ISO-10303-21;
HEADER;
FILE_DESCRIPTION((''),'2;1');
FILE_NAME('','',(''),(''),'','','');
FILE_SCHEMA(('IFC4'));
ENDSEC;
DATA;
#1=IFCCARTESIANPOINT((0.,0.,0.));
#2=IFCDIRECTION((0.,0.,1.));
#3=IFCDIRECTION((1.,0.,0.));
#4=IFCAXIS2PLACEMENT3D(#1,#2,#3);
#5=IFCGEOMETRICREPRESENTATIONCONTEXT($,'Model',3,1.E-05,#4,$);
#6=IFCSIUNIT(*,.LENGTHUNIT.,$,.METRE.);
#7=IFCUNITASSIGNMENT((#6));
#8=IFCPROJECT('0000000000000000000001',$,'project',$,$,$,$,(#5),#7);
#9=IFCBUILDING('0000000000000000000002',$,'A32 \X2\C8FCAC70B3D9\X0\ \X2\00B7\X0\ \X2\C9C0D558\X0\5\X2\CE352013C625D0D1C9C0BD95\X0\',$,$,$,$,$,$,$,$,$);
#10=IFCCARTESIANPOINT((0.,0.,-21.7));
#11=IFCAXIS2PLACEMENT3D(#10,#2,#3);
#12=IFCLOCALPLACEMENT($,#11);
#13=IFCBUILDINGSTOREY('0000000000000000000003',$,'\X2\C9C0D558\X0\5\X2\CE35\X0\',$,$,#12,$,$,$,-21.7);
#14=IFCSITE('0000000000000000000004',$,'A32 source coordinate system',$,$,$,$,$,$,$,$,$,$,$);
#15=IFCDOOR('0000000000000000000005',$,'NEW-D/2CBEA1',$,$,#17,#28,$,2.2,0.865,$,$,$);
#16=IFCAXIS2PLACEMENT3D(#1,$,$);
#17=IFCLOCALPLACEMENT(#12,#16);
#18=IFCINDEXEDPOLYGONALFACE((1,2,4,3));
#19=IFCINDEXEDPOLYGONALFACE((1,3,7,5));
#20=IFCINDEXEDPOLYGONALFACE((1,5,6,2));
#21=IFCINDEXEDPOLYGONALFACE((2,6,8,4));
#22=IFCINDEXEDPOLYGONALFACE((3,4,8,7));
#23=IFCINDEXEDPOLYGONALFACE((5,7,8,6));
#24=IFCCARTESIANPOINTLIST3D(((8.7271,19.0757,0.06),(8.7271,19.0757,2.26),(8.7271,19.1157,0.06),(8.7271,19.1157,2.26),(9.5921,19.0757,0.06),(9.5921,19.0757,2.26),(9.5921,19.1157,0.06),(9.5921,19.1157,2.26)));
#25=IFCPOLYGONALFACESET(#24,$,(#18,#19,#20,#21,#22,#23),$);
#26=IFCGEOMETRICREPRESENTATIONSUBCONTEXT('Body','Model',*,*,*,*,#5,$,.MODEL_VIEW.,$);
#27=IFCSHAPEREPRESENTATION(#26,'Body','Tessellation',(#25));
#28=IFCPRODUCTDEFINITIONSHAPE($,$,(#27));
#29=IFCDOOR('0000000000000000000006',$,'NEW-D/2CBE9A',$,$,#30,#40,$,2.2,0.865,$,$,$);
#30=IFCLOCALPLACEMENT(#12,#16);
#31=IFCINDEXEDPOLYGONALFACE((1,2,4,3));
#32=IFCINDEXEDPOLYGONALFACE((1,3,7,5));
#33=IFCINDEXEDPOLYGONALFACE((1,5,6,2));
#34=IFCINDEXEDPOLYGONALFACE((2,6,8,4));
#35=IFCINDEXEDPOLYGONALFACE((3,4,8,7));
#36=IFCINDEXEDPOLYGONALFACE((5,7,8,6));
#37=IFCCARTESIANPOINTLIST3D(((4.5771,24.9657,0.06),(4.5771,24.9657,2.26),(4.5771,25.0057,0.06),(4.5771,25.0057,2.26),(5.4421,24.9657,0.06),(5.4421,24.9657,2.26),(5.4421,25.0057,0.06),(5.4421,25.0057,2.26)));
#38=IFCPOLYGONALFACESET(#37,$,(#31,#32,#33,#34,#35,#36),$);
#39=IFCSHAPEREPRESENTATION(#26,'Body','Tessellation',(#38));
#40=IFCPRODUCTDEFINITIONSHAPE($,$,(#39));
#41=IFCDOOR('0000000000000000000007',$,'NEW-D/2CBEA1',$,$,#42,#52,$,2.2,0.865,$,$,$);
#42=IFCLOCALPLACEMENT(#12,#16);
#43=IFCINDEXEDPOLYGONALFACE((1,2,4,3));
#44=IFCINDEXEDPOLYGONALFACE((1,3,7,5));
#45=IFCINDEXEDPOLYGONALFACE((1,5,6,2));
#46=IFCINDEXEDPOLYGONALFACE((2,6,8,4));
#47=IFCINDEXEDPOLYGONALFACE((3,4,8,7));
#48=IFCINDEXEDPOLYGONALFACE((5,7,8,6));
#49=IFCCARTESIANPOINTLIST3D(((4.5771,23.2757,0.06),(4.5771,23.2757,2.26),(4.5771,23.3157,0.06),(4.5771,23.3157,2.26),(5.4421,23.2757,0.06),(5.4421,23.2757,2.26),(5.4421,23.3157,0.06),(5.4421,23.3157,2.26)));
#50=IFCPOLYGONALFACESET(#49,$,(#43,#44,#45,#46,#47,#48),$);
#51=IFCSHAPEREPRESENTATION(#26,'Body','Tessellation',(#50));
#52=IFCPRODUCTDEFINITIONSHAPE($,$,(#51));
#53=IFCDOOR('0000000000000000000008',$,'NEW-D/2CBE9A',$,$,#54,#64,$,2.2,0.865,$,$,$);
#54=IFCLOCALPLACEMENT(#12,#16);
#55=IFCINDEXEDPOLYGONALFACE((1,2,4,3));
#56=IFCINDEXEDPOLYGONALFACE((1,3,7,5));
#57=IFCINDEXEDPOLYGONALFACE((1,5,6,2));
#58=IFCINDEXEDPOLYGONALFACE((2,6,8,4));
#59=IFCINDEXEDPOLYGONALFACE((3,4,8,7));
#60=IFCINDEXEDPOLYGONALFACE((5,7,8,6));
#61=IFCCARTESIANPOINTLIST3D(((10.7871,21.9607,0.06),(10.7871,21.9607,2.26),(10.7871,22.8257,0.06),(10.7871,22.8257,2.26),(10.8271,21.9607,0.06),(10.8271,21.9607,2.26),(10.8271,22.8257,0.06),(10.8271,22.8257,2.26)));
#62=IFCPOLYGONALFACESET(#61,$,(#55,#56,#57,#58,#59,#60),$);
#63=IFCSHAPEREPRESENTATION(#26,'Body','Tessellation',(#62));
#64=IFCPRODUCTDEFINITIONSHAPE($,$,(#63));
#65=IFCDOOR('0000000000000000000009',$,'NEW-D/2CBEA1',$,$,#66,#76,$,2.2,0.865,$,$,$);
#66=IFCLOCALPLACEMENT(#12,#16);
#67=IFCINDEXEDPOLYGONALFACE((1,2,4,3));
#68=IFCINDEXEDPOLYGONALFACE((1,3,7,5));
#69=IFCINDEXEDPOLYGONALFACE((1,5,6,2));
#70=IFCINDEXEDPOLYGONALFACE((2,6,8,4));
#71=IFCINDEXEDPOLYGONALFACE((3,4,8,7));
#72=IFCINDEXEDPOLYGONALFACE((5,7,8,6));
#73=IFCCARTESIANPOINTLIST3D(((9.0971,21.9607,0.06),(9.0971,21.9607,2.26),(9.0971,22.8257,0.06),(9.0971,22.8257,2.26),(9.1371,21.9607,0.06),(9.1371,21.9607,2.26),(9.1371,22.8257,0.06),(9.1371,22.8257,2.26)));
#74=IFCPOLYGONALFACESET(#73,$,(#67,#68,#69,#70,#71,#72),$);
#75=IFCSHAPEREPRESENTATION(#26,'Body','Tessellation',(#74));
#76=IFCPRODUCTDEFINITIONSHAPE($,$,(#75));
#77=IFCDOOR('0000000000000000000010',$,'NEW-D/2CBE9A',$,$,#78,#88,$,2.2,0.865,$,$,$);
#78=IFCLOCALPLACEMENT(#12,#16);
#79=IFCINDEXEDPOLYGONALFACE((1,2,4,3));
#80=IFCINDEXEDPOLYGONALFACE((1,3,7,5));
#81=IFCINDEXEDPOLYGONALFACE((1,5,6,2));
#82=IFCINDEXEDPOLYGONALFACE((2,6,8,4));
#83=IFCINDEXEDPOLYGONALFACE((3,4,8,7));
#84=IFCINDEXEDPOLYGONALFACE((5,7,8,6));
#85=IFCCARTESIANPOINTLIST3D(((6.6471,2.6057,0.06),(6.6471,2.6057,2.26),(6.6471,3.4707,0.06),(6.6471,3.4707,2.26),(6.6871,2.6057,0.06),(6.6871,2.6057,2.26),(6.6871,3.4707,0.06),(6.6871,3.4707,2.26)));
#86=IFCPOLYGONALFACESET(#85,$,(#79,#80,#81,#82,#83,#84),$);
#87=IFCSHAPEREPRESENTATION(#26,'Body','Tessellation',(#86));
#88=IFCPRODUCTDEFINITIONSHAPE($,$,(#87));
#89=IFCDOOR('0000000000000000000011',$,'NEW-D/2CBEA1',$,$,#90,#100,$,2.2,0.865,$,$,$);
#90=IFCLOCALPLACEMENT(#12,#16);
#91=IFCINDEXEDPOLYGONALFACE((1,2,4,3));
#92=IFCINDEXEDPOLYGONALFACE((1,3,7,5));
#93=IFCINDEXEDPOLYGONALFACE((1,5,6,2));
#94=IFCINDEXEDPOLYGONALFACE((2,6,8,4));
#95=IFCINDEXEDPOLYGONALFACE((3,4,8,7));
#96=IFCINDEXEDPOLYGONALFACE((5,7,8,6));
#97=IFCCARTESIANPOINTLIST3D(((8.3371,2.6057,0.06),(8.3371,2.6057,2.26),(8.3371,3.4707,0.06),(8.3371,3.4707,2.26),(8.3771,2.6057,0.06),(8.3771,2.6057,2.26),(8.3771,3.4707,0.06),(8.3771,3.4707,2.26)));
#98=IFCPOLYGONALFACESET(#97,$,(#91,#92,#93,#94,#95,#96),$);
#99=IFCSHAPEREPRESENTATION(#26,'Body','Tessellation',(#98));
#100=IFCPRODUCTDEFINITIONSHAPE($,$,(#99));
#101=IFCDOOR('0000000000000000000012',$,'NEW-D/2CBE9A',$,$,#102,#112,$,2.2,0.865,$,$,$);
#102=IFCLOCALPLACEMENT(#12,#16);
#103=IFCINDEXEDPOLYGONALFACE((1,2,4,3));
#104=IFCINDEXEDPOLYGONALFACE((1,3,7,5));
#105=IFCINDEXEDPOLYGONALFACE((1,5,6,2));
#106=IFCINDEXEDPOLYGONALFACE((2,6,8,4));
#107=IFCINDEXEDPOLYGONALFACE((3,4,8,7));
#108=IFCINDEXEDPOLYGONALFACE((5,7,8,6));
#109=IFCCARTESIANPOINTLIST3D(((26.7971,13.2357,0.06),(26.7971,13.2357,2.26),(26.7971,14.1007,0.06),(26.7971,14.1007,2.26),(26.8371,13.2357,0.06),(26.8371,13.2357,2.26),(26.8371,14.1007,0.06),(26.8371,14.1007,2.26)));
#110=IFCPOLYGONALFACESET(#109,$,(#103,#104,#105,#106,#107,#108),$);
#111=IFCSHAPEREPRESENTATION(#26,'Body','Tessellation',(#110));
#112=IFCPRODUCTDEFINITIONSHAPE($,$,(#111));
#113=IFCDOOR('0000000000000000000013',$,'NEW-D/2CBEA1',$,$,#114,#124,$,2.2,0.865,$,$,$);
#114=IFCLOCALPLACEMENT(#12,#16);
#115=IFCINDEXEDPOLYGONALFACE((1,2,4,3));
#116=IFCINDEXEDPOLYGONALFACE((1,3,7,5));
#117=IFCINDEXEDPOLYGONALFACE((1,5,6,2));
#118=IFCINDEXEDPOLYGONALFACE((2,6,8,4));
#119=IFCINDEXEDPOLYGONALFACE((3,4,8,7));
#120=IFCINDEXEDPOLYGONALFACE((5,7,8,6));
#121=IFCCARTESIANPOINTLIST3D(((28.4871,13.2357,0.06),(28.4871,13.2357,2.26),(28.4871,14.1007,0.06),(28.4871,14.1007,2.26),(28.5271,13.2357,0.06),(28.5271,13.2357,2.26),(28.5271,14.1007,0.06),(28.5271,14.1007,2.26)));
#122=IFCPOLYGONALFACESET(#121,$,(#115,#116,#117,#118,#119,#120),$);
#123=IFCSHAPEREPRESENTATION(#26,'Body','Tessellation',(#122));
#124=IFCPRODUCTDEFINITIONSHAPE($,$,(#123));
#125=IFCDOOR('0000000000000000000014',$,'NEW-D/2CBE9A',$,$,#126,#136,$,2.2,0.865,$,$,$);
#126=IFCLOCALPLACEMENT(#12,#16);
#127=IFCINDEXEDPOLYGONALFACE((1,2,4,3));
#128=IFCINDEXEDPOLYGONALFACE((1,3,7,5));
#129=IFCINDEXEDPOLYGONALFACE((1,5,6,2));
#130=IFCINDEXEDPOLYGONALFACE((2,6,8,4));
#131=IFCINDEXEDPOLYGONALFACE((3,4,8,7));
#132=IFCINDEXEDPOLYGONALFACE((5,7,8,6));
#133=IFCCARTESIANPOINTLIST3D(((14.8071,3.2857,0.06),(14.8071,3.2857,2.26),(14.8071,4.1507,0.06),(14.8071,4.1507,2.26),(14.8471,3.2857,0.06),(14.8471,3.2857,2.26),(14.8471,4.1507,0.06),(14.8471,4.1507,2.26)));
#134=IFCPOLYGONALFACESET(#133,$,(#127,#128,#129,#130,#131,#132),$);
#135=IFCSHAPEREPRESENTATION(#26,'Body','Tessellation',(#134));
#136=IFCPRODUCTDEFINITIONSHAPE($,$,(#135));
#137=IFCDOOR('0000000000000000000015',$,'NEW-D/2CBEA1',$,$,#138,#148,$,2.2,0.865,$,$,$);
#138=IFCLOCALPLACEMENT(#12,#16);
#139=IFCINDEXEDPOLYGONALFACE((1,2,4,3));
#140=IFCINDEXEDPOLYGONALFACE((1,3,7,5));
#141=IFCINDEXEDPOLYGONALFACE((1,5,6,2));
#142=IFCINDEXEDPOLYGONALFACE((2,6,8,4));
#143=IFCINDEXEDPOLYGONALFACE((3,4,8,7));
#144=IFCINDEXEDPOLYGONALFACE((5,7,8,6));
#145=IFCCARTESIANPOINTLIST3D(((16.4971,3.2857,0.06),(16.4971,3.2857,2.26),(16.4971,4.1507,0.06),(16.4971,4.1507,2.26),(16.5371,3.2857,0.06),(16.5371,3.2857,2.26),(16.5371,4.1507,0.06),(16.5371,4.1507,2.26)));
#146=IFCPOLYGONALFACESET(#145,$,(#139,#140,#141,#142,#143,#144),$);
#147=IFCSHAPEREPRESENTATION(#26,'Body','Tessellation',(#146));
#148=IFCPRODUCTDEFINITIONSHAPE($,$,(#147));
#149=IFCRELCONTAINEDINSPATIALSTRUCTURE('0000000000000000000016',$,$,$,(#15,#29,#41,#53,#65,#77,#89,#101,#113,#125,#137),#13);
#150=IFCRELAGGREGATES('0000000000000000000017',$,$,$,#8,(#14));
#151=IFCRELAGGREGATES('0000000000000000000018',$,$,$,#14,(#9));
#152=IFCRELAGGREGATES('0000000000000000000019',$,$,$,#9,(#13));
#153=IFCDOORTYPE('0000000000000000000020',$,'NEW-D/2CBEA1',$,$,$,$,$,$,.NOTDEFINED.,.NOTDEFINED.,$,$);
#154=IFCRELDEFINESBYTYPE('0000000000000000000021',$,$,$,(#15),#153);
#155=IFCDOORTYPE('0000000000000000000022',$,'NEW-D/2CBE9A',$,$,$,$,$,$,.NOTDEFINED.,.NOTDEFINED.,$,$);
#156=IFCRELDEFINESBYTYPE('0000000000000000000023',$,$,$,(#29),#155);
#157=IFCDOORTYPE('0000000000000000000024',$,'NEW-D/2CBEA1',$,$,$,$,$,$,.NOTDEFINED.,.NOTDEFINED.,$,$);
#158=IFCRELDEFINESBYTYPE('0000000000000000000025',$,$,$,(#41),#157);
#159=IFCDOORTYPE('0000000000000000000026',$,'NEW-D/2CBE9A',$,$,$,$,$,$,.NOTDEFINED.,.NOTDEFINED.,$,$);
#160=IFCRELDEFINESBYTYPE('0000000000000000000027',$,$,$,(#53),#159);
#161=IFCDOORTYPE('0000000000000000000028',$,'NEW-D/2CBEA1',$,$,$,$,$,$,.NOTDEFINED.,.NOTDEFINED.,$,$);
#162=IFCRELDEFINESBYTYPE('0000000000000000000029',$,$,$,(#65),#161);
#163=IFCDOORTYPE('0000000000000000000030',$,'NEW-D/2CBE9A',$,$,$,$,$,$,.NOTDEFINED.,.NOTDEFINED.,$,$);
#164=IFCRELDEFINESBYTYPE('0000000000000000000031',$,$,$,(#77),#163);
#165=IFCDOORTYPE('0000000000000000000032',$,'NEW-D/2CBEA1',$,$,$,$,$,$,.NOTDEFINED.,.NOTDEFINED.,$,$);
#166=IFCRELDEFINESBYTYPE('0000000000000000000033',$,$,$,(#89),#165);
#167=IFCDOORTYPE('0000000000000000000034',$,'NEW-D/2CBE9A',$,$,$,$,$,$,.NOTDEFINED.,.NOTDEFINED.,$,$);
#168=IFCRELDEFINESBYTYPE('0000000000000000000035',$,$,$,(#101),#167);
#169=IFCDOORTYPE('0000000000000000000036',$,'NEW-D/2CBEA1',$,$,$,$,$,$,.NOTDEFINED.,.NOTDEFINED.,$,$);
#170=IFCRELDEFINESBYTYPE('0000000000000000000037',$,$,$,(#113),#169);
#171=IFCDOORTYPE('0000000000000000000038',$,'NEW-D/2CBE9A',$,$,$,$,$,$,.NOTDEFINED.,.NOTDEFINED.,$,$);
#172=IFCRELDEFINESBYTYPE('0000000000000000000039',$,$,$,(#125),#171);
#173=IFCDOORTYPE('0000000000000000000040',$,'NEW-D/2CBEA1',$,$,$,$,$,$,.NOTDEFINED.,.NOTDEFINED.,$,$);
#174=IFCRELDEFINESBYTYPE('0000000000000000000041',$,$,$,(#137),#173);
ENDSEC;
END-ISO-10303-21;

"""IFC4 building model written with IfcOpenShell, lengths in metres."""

from ifc_helpers import new_model, si_unit, frame, origin, origin_with_axes, place, context, subcontext, project, spatial, polyline, outline, extrude, source, transform, mapped, type_object, type_shapes, element, save


model = new_model("IFC4")

# Units and contexts
model_context = context("Model", 3, precision=1e-05, world=origin_with_axes())
body_context = subcontext(model_context, "Body", "Model", "MODEL_VIEW")
ifc_project = project(units=[si_unit("LENGTHUNIT", "METRE")], contexts=[model_context])

# Site, building, storey
storey_placement = place(None, frame((0.0, 0.0, -21.7), z_axis=(0.0, 0.0, 1.0), x_axis=(1.0, 0.0, 0.0)))
site = spatial("IfcSite", under=ifc_project, Name="A32 source coordinate system")
building = spatial("IfcBuilding", under=site, Name="A32 주거동 · 지하5층–옥탑지붕")
storey = spatial("IfcBuildingStorey", under=building, at=storey_placement, Name="지하5층", Elevation=-21.7)

# Doors
door_type_1 = type_object("IfcDoorType", Name="NEW-D/2CBEA1", OperationType="NOTDEFINED", PredefinedType="NOTDEFINED")
shared_shape_1 = source(origin(), body_context, "Body", "SweptSolid", [
    extrude(outline(polyline([(9.5921, 19.0757), (8.7271, 19.0757), (8.7271, 19.1157), (9.5921, 19.1157), (9.5921, 19.0757)])), frame((0.0, 0.0, 0.06)), (0.0, 0.0, 1.0), 2.2),
])
type_shapes(door_type_1, [shared_shape_1])
door_1_placement = place(storey_placement, origin_with_axes())
element("IfcDoor", 1, at=door_1_placement, inside=storey, type_object=door_type_1, Name="NEW-D/2CBEA1", OverallHeight=2.2, OverallWidth=0.865, context=body_context, shape_type="MappedRepresentation", body=[
    mapped(shared_shape_1, transform((0.0, 0.0, 0.0), scale=1.0)),
])
door_type_2 = type_object("IfcDoorType", Name="NEW-D/2CBE9A", OperationType="NOTDEFINED", PredefinedType="NOTDEFINED")
shared_shape_2 = source(origin(), body_context, "Body", "SweptSolid", [
    extrude(outline(polyline([(4.5771, 24.9657), (4.5771, 25.0057), (5.4421, 25.0057), (5.4421, 24.9657), (4.5771, 24.9657)])), frame((0.0, 0.0, 0.06)), (0.0, 0.0, 1.0), 2.2),
])
type_shapes(door_type_2, [shared_shape_2])
door_2_placement = place(storey_placement, origin_with_axes())
element("IfcDoor", 2, at=door_2_placement, inside=storey, type_object=door_type_2, Name="NEW-D/2CBE9A", OverallHeight=2.2, OverallWidth=0.865, context=body_context, shape_type="MappedRepresentation", body=[
    mapped(shared_shape_2, transform((0.0, 0.0, 0.0), scale=1.0)),
])
door_type_3 = type_object("IfcDoorType", Name="NEW-D/2CBEA1", OperationType="NOTDEFINED", PredefinedType="NOTDEFINED")
shared_shape_3 = source(origin(), body_context, "Body", "SweptSolid", [
    extrude(outline(polyline([(5.4421, 23.2757), (4.5771, 23.2757), (4.5771, 23.3157), (5.4421, 23.3157), (5.4421, 23.2757)])), frame((0.0, 0.0, 0.06)), (0.0, 0.0, 1.0), 2.2),
])
type_shapes(door_type_3, [shared_shape_3])
door_3_placement = place(storey_placement, origin_with_axes())
element("IfcDoor", 3, at=door_3_placement, inside=storey, type_object=door_type_3, Name="NEW-D/2CBEA1", OverallHeight=2.2, OverallWidth=0.865, context=body_context, shape_type="MappedRepresentation", body=[
    mapped(shared_shape_3, transform((0.0, 0.0, 0.0), scale=1.0)),
])
door_type_4 = type_object("IfcDoorType", Name="NEW-D/2CBE9A", OperationType="NOTDEFINED", PredefinedType="NOTDEFINED")
shared_shape_4 = source(origin(), body_context, "Body", "SweptSolid", [
    extrude(outline(polyline([(10.7871, 22.8257), (10.8271, 22.8257), (10.8271, 21.9607), (10.7871, 21.9607), (10.7871, 22.8257)])), frame((0.0, 0.0, 0.06)), (0.0, 0.0, 1.0), 2.2),
])
type_shapes(door_type_4, [shared_shape_4])
door_4_placement = place(storey_placement, origin_with_axes())
element("IfcDoor", 4, at=door_4_placement, inside=storey, type_object=door_type_4, Name="NEW-D/2CBE9A", OverallHeight=2.2, OverallWidth=0.865, context=body_context, shape_type="MappedRepresentation", body=[
    mapped(shared_shape_4, transform((0.0, 0.0, 0.0), scale=1.0)),
])
door_type_5 = type_object("IfcDoorType", Name="NEW-D/2CBEA1", OperationType="NOTDEFINED", PredefinedType="NOTDEFINED")
shared_shape_5 = source(origin(), body_context, "Body", "SweptSolid", [
    extrude(outline(polyline([(9.0971, 21.9607), (9.0971, 22.8257), (9.1371, 22.8257), (9.1371, 21.9607), (9.0971, 21.9607)])), frame((0.0, 0.0, 0.06)), (0.0, 0.0, 1.0), 2.2),
])
type_shapes(door_type_5, [shared_shape_5])
door_5_placement = place(storey_placement, origin_with_axes())
element("IfcDoor", 5, at=door_5_placement, inside=storey, type_object=door_type_5, Name="NEW-D/2CBEA1", OverallHeight=2.2, OverallWidth=0.865, context=body_context, shape_type="MappedRepresentation", body=[
    mapped(shared_shape_5, transform((0.0, 0.0, 0.0), scale=1.0)),
])
door_type_6 = type_object("IfcDoorType", Name="NEW-D/2CBE9A", OperationType="NOTDEFINED", PredefinedType="NOTDEFINED")
shared_shape_6 = source(origin(), body_context, "Body", "SweptSolid", [
    extrude(outline(polyline([(6.6871, 2.6057), (6.6471, 2.6057), (6.6471, 3.4707), (6.6871, 3.4707), (6.6871, 2.6057)])), frame((0.0, 0.0, 0.06)), (0.0, 0.0, 1.0), 2.2),
])
type_shapes(door_type_6, [shared_shape_6])
door_6_placement = place(storey_placement, origin_with_axes())
element("IfcDoor", 6, at=door_6_placement, inside=storey, type_object=door_type_6, Name="NEW-D/2CBE9A", OverallHeight=2.2, OverallWidth=0.865, context=body_context, shape_type="MappedRepresentation", body=[
    mapped(shared_shape_6, transform((0.0, 0.0, 0.0), scale=1.0)),
])
door_type_7 = type_object("IfcDoorType", Name="NEW-D/2CBEA1", OperationType="NOTDEFINED", PredefinedType="NOTDEFINED")
shared_shape_7 = source(origin(), body_context, "Body", "SweptSolid", [
    extrude(outline(polyline([(8.3771, 3.4707), (8.3771, 2.6057), (8.3371, 2.6057), (8.3371, 3.4707), (8.3771, 3.4707)])), frame((0.0, 0.0, 0.06)), (0.0, 0.0, 1.0), 2.2),
])
type_shapes(door_type_7, [shared_shape_7])
door_7_placement = place(storey_placement, origin_with_axes())
element("IfcDoor", 7, at=door_7_placement, inside=storey, type_object=door_type_7, Name="NEW-D/2CBEA1", OverallHeight=2.2, OverallWidth=0.865, context=body_context, shape_type="MappedRepresentation", body=[
    mapped(shared_shape_7, transform((0.0, 0.0, 0.0), scale=1.0)),
])
door_type_8 = type_object("IfcDoorType", Name="NEW-D/2CBE9A", OperationType="NOTDEFINED", PredefinedType="NOTDEFINED")
shared_shape_8 = source(origin(), body_context, "Body", "SweptSolid", [
    extrude(outline(polyline([(26.8371, 13.2357), (26.7971, 13.2357), (26.7971, 14.1007), (26.8371, 14.1007), (26.8371, 13.2357)])), frame((0.0, 0.0, 0.06)), (0.0, 0.0, 1.0), 2.2),
])
type_shapes(door_type_8, [shared_shape_8])
door_8_placement = place(storey_placement, origin_with_axes())
element("IfcDoor", 8, at=door_8_placement, inside=storey, type_object=door_type_8, Name="NEW-D/2CBE9A", OverallHeight=2.2, OverallWidth=0.865, context=body_context, shape_type="MappedRepresentation", body=[
    mapped(shared_shape_8, transform((0.0, 0.0, 0.0), scale=1.0)),
])
door_type_9 = type_object("IfcDoorType", Name="NEW-D/2CBEA1", OperationType="NOTDEFINED", PredefinedType="NOTDEFINED")
shared_shape_9 = source(origin(), body_context, "Body", "SweptSolid", [
    extrude(outline(polyline([(28.5271, 14.1007), (28.5271, 13.2357), (28.4871, 13.2357), (28.4871, 14.1007), (28.5271, 14.1007)])), frame((0.0, 0.0, 0.06)), (0.0, 0.0, 1.0), 2.2),
])
type_shapes(door_type_9, [shared_shape_9])
door_9_placement = place(storey_placement, origin_with_axes())
element("IfcDoor", 9, at=door_9_placement, inside=storey, type_object=door_type_9, Name="NEW-D/2CBEA1", OverallHeight=2.2, OverallWidth=0.865, context=body_context, shape_type="MappedRepresentation", body=[
    mapped(shared_shape_9, transform((0.0, 0.0, 0.0), scale=1.0)),
])
door_type_10 = type_object("IfcDoorType", Name="NEW-D/2CBE9A", OperationType="NOTDEFINED", PredefinedType="NOTDEFINED")
shared_shape_10 = source(origin(), body_context, "Body", "SweptSolid", [
    extrude(outline(polyline([(14.8471, 3.2857), (14.8071, 3.2857), (14.8071, 4.1507), (14.8471, 4.1507), (14.8471, 3.2857)])), frame((0.0, 0.0, 0.06)), (0.0, 0.0, 1.0), 2.2),
])
type_shapes(door_type_10, [shared_shape_10])
door_10_placement = place(storey_placement, origin_with_axes())
element("IfcDoor", 10, at=door_10_placement, inside=storey, type_object=door_type_10, Name="NEW-D/2CBE9A", OverallHeight=2.2, OverallWidth=0.865, context=body_context, shape_type="MappedRepresentation", body=[
    mapped(shared_shape_10, transform((0.0, 0.0, 0.0), scale=1.0)),
])
door_type_11 = type_object("IfcDoorType", Name="NEW-D/2CBEA1", OperationType="NOTDEFINED", PredefinedType="NOTDEFINED")
shared_shape_11 = source(origin(), body_context, "Body", "SweptSolid", [
    extrude(outline(polyline([(16.5371, 4.1507), (16.5371, 3.2857), (16.4971, 3.2857), (16.4971, 4.1507), (16.5371, 4.1507)])), frame((0.0, 0.0, 0.06)), (0.0, 0.0, 1.0), 2.2),
])
type_shapes(door_type_11, [shared_shape_11])
door_11_placement = place(storey_placement, origin_with_axes())
element("IfcDoor", 11, at=door_11_placement, inside=storey, type_object=door_type_11, Name="NEW-D/2CBEA1", OverallHeight=2.2, OverallWidth=0.865, context=body_context, shape_type="MappedRepresentation", body=[
    mapped(shared_shape_11, transform((0.0, 0.0, 0.0), scale=1.0)),
])

save(model, "model.ifc")
